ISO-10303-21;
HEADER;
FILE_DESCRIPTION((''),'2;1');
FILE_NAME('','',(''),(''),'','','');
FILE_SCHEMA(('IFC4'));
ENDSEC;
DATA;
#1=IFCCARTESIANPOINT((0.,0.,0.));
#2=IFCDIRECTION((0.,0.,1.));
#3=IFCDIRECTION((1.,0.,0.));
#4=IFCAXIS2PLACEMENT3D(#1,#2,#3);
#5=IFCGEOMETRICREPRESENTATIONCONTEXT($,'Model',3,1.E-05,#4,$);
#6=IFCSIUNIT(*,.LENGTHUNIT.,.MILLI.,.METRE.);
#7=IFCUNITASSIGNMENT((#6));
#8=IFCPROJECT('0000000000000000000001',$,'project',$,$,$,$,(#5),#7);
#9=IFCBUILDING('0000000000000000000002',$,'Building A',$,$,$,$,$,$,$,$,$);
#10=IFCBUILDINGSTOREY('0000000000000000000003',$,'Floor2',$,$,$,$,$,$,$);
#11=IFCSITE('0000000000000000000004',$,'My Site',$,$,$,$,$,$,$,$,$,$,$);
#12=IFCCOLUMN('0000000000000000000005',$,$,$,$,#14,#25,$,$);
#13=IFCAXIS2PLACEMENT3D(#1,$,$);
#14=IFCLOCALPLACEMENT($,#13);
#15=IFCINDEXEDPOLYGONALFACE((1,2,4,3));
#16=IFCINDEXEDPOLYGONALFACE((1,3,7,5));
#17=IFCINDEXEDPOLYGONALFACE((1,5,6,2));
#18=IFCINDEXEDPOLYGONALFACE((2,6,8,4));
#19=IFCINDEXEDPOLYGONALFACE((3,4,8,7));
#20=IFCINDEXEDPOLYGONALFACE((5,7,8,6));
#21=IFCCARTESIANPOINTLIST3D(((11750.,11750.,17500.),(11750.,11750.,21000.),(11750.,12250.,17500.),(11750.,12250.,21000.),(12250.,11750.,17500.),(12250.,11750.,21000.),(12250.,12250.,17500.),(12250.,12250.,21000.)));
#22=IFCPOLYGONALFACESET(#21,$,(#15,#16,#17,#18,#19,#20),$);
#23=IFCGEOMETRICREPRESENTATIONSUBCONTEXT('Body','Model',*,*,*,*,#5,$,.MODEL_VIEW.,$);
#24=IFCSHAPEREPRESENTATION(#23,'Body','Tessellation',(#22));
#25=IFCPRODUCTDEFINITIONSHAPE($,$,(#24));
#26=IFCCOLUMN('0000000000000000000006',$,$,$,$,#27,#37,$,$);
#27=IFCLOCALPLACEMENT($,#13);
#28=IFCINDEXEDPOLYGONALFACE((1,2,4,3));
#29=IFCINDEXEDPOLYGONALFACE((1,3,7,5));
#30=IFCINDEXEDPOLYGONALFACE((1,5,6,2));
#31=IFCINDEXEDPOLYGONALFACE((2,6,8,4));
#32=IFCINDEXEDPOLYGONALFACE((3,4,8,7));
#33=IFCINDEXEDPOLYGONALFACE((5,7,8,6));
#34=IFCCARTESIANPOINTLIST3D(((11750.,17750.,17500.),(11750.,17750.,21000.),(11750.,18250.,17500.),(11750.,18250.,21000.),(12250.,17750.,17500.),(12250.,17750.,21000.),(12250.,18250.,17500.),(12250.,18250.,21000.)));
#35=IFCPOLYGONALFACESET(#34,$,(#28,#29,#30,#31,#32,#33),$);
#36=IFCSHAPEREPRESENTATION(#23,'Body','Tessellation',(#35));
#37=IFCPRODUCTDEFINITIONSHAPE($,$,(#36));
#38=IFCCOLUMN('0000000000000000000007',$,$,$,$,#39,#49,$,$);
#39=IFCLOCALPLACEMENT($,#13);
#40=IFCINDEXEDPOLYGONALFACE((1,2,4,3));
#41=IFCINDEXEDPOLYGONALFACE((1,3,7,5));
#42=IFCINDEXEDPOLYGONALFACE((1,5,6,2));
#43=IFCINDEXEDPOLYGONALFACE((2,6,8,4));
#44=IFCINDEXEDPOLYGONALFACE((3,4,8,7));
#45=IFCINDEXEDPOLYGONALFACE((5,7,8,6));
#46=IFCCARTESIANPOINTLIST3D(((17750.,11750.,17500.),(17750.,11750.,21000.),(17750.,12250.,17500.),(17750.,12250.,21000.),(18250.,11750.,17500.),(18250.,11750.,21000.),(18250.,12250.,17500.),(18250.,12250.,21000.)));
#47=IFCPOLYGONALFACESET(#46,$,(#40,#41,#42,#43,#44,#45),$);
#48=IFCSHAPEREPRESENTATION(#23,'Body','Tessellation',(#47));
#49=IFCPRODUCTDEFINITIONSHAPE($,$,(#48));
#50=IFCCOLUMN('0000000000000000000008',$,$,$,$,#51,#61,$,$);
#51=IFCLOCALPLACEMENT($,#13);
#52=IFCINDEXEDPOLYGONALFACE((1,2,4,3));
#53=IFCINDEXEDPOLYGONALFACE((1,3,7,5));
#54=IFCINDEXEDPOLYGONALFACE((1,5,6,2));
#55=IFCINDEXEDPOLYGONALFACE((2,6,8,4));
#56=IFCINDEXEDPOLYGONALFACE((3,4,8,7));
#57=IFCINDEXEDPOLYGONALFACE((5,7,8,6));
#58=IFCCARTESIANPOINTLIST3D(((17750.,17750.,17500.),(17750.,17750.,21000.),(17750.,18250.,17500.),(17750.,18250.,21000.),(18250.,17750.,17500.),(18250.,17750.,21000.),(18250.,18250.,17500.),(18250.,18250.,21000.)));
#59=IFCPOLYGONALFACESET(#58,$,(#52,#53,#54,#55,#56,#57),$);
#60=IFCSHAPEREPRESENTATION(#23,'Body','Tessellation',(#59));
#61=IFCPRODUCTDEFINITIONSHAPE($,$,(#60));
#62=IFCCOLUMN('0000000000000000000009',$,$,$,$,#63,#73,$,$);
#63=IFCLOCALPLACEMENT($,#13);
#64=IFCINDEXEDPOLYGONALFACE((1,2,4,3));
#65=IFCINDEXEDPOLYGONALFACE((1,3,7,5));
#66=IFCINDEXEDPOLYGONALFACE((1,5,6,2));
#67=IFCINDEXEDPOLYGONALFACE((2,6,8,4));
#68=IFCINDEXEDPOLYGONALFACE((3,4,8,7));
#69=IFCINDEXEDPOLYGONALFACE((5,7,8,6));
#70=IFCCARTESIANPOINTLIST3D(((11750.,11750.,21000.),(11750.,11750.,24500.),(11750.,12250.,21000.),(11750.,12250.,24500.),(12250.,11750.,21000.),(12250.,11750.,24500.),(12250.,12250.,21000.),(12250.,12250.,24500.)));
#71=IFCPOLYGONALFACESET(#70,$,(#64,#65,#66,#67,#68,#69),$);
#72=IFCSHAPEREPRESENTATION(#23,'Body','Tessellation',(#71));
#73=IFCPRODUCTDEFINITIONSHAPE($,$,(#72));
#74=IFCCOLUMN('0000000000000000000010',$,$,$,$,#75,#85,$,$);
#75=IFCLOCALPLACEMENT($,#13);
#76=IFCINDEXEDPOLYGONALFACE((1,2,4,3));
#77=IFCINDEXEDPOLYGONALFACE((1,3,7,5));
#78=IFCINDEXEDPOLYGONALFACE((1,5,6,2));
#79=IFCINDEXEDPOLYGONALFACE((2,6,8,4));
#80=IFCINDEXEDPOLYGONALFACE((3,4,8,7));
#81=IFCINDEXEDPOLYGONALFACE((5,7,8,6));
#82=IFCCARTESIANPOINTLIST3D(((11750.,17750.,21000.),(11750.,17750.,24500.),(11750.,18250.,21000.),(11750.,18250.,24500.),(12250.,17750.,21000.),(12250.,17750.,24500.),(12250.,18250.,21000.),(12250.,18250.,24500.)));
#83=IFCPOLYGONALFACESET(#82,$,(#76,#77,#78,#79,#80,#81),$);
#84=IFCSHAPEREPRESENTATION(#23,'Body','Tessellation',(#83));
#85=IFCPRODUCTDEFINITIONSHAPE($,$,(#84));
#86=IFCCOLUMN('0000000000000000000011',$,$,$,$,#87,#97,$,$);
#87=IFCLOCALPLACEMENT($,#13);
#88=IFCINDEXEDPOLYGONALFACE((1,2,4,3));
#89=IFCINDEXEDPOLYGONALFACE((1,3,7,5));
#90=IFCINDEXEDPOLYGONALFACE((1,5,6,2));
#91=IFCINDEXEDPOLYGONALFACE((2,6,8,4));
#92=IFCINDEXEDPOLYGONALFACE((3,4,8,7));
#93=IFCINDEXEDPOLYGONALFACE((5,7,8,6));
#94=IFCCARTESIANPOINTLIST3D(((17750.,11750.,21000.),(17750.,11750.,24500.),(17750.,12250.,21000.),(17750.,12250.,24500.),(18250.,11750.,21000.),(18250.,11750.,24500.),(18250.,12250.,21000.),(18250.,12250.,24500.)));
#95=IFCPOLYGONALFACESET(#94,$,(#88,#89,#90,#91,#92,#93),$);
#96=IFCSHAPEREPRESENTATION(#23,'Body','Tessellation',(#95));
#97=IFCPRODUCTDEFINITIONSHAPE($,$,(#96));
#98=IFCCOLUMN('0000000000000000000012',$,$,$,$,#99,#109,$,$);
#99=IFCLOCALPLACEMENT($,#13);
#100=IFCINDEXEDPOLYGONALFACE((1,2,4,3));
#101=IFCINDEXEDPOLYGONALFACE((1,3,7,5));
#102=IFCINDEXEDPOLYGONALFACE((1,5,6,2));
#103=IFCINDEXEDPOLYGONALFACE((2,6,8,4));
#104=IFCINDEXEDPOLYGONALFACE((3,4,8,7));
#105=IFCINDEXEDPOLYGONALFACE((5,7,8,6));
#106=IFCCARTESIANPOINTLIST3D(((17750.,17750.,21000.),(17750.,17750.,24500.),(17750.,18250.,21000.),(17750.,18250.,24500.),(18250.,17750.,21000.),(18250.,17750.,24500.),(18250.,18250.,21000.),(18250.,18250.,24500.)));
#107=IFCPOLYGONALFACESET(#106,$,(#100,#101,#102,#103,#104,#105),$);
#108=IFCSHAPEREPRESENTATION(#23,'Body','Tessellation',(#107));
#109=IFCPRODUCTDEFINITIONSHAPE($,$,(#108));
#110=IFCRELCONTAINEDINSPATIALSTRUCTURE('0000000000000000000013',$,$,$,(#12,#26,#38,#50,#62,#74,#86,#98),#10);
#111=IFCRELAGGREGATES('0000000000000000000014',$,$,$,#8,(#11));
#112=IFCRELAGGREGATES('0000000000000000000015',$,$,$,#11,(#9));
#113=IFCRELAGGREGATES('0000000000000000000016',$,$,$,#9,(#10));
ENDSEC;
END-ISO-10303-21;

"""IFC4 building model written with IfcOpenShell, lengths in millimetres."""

from ifc_helpers import new_model, si_unit, frame, origin_with_axes, place, context, subcontext, project, spatial, line, indexed_curve, outline, extrude, element, save


model = new_model("IFC4")

# Units and contexts
model_context = context("Model", 3, precision=1e-05, world=origin_with_axes())
body_context = subcontext(model_context, "Body", "Model", "MODEL_VIEW")
ifc_project = project(units=[si_unit("LENGTHUNIT", "METRE", prefix="MILLI")], contexts=[model_context])

# Site, building, storey
site = spatial("IfcSite", under=ifc_project, Name="My Site")
building = spatial("IfcBuilding", under=site, Name="Building A")
storey = spatial("IfcBuildingStorey", under=building, Name="Floor2")

# Columns
for number, where, z_axis, x_axis in (
    (1, (12000.0, 12000.0, 17500.0), (0.0, 0.0, 1.0), (1.0, 0.0, 0.0)),
    (2, (12000.0, 18000.0, 17500.0), (0.0, 0.0, 1.0), (1.0, 0.0, 0.0)),
    (3, (18000.0, 12000.0, 17500.0), (0.0, 0.0, 1.0), (1.0, 0.0, 0.0)),
    (4, (18000.0, 18000.0, 17500.0), (0.0, 0.0, 1.0), (1.0, 0.0, 0.0)),
    (5, (12000.0, 12000.0, 21000.0), (0.0, 0.0, 1.0), (1.0, 0.0, 0.0)),
    (6, (12000.0, 18000.0, 21000.0), (0.0, 0.0, 1.0), (1.0, 0.0, 0.0)),
    (7, (18000.0, 12000.0, 21000.0), (0.0, 0.0, 1.0), (1.0, 0.0, 0.0)),
    (8, (18000.0, 18000.0, 21000.0), (0.0, 0.0, 1.0), (1.0, 0.0, 0.0)),
):
    element("IfcColumn", number, at=place(None, frame(where, z_axis=z_axis, x_axis=x_axis)), inside=storey, context=body_context, shape_type="SweptSolid", body=[
        extrude(outline(indexed_curve([(-250.0, -250.0), (250.0, -250.0), (250.0, 250.0), (-250.0, 250.0)], segments=[line(1, 2, 3, 4, 1)])), origin_with_axes(), (0.0, 0.0, 1.0), 3500.0),
    ])

save(model, "model.ifc")
